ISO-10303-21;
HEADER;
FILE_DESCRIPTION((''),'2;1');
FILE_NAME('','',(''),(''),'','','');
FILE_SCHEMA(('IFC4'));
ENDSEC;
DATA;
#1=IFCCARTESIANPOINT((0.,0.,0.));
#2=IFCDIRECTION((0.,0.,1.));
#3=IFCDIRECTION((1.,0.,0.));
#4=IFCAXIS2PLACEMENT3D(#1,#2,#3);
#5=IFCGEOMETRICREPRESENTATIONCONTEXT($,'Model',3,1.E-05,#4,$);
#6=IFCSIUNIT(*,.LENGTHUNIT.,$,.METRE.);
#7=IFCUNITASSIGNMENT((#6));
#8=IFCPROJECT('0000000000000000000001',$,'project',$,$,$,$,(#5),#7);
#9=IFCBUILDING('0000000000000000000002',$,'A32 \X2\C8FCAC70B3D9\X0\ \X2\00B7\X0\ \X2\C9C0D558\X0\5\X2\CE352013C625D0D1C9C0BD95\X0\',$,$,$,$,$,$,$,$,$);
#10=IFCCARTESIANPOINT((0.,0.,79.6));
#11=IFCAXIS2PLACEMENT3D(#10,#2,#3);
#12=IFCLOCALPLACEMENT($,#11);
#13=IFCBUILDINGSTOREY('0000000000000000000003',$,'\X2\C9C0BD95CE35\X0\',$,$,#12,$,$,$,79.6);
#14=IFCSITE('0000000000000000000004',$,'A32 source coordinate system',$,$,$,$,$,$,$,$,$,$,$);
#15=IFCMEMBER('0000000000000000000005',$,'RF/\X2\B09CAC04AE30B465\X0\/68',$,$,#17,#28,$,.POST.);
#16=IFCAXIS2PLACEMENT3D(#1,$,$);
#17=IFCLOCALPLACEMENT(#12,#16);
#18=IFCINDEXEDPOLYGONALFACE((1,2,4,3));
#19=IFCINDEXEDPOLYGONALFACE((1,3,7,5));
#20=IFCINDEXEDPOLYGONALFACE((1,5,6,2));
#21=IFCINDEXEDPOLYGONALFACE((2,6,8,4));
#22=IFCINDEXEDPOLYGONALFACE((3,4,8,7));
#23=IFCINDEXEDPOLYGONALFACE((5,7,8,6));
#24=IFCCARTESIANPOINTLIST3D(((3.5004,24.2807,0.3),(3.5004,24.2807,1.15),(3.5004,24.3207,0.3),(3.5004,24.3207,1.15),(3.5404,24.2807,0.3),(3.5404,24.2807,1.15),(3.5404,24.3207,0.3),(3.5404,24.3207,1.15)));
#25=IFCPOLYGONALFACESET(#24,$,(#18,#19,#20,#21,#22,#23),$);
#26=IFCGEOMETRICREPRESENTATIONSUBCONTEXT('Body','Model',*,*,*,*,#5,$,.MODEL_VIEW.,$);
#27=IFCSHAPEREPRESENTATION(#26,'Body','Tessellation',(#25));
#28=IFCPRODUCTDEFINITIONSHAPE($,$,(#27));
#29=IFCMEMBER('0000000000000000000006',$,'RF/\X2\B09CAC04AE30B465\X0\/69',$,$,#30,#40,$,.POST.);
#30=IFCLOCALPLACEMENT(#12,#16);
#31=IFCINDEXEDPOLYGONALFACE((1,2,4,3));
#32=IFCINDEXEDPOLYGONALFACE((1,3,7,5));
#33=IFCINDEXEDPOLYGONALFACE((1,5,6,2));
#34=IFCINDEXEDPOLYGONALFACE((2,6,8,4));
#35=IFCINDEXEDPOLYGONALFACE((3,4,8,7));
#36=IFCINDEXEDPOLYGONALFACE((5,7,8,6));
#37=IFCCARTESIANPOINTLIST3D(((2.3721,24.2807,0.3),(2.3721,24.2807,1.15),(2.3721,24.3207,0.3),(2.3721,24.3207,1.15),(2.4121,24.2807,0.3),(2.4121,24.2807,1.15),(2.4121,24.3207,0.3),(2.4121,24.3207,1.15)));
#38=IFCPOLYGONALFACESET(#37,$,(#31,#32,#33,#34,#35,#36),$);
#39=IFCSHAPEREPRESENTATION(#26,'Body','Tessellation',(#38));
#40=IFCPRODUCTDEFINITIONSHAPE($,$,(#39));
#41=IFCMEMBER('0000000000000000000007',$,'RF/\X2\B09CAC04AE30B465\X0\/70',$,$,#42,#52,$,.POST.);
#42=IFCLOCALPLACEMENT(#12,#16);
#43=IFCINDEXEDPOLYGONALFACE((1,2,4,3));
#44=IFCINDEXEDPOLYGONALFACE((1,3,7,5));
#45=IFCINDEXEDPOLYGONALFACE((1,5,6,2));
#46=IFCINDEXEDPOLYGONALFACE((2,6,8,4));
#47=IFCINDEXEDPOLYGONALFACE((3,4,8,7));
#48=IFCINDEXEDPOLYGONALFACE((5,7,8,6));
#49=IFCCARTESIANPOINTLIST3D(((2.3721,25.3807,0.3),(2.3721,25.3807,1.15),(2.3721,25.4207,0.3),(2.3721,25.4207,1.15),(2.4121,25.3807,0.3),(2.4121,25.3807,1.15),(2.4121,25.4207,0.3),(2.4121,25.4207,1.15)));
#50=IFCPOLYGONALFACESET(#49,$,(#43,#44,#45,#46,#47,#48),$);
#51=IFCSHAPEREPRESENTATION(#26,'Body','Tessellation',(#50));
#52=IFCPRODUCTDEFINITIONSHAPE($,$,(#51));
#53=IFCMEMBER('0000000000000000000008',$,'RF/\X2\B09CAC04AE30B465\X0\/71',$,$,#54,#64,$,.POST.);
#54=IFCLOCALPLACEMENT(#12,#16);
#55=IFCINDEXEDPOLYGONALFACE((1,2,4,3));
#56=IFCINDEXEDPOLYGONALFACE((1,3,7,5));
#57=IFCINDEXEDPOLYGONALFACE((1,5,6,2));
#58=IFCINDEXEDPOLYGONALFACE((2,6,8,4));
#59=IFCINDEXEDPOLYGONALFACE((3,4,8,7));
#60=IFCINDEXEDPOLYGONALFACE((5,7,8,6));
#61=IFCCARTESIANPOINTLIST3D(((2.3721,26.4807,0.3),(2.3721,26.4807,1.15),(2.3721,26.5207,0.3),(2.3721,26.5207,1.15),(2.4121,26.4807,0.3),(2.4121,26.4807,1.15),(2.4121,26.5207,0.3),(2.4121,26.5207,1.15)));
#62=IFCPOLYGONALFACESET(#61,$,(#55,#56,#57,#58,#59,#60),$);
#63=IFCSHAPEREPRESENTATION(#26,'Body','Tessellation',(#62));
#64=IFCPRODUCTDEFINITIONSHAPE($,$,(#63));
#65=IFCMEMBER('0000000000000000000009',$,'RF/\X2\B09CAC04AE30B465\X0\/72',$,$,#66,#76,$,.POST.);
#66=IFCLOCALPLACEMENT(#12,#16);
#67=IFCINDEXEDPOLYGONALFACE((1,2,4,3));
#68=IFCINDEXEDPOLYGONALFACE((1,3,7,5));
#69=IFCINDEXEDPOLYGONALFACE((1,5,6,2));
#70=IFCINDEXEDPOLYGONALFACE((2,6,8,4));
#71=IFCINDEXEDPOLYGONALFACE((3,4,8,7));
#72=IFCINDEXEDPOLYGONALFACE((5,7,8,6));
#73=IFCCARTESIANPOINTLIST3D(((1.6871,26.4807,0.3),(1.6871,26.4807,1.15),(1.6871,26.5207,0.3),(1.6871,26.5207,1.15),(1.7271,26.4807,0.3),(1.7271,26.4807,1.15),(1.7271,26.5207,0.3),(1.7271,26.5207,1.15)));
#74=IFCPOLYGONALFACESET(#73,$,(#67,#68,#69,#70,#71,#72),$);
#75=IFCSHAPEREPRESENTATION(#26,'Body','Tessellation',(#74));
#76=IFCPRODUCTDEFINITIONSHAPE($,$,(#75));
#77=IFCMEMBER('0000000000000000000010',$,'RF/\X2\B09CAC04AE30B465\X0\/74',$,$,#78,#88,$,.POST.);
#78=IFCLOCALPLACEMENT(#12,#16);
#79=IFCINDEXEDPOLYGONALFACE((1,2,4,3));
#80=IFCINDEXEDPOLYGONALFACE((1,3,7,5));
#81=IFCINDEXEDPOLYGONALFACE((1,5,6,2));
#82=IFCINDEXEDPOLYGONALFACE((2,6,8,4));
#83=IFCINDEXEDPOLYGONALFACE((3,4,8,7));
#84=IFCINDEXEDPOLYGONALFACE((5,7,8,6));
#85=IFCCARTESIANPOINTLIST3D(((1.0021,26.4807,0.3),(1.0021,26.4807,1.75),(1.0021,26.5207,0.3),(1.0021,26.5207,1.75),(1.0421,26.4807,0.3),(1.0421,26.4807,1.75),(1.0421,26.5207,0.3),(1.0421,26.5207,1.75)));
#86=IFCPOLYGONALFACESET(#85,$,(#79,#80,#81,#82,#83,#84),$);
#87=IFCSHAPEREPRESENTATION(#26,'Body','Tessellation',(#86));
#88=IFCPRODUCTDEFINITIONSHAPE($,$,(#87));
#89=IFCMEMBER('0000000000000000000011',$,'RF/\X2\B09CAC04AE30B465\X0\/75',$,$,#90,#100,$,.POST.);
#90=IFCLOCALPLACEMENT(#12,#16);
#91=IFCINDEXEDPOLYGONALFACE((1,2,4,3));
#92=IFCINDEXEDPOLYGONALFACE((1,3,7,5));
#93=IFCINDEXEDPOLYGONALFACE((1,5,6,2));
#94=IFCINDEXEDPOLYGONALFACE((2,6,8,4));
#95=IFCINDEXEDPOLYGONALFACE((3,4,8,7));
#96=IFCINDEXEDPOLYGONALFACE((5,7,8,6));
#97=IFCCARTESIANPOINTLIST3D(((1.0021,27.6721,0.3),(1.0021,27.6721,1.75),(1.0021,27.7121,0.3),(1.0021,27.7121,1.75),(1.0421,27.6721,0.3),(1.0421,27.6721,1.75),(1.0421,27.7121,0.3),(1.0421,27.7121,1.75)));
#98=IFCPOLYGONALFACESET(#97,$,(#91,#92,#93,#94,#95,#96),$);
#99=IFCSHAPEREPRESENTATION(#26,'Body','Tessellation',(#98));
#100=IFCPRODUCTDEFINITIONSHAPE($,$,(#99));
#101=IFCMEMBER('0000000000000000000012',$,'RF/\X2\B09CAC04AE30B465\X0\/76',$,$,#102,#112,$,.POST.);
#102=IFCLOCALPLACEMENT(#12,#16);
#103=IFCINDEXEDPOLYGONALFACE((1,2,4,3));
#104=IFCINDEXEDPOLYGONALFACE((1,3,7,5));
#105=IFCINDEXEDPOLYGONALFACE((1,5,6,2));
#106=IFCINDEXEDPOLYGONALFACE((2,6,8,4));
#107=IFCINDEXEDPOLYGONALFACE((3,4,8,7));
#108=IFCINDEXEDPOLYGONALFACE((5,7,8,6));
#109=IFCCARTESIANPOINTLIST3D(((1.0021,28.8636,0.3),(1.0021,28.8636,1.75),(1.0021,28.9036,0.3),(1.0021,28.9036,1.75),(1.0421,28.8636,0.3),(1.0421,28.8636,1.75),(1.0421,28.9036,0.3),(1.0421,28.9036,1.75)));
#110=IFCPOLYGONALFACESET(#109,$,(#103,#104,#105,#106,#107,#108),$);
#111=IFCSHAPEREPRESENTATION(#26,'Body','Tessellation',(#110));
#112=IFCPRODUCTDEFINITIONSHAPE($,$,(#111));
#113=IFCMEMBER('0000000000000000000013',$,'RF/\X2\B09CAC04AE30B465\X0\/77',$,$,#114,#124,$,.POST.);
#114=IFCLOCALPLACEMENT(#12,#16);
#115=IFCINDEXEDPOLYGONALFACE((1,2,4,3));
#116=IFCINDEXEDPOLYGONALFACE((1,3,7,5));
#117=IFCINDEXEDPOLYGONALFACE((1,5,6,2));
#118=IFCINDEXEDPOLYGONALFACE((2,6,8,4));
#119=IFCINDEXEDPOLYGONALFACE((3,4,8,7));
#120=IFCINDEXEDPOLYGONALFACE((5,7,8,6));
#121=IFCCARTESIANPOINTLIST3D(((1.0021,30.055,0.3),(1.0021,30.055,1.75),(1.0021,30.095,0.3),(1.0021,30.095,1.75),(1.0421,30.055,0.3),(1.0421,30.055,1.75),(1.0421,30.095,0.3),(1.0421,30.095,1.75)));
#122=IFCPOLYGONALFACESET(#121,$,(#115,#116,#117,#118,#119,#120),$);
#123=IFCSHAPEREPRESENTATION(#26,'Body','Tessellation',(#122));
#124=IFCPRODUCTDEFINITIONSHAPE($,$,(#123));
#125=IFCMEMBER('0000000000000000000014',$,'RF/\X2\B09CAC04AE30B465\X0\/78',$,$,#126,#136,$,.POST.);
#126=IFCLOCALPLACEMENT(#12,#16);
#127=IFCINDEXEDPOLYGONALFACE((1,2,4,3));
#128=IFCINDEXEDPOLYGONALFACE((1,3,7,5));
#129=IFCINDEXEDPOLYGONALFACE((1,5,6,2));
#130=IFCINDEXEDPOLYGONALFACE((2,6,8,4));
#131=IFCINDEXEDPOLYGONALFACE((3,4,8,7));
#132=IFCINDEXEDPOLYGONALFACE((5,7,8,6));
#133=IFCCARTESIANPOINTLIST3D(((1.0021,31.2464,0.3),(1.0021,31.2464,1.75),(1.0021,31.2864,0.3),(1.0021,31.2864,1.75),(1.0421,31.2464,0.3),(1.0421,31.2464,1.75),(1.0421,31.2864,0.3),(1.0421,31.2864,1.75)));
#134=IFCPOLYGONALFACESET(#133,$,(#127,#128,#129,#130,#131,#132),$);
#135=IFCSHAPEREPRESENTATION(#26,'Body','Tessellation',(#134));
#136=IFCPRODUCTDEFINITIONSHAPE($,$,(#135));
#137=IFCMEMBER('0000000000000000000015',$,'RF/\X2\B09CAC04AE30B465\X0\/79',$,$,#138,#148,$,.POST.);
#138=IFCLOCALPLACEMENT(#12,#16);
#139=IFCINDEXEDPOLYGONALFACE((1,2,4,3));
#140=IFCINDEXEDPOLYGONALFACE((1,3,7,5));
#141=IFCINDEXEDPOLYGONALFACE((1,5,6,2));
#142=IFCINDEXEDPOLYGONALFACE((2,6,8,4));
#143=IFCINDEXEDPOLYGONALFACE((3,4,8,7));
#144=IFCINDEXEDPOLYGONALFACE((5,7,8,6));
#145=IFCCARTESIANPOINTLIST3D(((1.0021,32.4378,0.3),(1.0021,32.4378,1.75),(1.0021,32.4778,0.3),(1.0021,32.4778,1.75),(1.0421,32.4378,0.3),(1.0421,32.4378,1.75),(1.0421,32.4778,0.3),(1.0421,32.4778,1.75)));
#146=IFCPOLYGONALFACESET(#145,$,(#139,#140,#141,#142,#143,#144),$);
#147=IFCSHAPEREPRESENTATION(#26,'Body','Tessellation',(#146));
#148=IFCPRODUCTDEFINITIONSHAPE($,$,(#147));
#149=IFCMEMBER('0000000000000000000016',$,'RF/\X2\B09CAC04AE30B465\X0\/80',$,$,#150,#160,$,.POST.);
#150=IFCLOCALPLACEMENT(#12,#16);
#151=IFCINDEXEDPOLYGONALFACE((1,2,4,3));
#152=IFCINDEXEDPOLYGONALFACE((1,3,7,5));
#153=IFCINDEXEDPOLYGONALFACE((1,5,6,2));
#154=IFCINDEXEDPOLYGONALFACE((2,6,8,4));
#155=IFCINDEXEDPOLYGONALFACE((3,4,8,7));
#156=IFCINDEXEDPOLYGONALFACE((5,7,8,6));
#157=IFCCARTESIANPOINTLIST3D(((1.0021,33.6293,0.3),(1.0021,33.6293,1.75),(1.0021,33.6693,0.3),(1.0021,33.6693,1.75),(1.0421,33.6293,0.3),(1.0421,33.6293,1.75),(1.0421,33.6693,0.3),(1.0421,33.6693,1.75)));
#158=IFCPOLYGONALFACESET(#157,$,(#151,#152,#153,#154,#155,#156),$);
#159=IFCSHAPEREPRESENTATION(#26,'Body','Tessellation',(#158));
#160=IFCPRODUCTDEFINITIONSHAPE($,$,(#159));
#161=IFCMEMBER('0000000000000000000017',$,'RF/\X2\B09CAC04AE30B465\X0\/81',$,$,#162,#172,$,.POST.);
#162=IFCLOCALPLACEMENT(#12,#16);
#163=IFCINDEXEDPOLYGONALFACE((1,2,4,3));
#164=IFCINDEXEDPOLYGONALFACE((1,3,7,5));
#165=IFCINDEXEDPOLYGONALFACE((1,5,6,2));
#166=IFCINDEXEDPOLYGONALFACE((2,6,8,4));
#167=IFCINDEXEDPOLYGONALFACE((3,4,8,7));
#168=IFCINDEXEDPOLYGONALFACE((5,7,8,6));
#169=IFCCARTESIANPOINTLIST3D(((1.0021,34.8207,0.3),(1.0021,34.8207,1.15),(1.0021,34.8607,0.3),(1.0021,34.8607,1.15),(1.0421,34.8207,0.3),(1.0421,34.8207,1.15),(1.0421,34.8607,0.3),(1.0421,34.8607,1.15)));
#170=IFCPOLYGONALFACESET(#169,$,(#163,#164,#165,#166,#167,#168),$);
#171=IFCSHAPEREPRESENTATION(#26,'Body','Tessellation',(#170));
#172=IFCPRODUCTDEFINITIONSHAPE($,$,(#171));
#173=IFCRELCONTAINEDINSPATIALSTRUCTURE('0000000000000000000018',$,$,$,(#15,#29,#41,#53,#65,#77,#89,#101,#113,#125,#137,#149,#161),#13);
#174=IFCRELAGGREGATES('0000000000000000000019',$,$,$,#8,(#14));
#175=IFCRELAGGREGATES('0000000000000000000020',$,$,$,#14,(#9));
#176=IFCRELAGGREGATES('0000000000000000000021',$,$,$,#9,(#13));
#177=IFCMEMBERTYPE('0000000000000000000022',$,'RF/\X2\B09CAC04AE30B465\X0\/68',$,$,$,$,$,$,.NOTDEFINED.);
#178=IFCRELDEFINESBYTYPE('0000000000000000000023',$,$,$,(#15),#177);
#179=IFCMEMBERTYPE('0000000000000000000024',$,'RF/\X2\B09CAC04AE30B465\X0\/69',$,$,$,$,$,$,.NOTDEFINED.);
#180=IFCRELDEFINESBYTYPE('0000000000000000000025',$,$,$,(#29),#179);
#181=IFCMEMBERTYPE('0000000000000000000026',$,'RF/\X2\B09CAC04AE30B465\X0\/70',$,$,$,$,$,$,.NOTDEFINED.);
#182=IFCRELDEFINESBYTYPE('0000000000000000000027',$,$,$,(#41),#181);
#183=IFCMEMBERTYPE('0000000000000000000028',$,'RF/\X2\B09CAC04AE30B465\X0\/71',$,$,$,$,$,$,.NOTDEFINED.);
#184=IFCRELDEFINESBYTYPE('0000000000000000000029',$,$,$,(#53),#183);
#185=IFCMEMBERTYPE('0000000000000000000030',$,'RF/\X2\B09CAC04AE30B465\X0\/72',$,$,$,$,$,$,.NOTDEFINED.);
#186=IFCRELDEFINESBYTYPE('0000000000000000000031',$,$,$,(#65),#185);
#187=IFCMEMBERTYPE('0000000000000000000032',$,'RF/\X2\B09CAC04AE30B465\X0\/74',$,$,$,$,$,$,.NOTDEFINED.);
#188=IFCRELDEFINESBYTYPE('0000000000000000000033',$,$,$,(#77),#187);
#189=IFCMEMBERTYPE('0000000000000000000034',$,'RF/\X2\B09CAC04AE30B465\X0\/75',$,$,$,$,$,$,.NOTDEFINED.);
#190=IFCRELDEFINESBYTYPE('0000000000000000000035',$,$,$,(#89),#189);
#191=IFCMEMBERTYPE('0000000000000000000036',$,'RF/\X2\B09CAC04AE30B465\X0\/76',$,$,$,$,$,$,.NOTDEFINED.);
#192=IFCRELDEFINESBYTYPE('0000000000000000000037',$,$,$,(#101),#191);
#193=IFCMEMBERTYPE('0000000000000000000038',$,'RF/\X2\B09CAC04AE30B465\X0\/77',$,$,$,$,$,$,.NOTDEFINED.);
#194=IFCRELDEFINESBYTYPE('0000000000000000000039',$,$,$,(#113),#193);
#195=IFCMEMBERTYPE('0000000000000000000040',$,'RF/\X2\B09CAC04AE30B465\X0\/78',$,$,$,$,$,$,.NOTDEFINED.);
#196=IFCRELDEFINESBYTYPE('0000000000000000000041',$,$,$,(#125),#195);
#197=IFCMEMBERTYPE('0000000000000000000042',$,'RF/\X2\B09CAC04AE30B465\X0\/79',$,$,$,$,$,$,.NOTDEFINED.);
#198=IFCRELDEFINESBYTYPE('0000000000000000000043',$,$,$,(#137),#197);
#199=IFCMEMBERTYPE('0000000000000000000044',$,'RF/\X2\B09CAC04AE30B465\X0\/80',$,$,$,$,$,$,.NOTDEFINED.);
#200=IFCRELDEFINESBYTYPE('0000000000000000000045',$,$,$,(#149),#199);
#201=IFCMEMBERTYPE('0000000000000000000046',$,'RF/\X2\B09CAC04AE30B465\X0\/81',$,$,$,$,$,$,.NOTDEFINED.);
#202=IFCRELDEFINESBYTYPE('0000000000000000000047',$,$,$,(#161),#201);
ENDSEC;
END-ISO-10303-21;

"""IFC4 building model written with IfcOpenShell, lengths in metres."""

from ifc_helpers import new_model, si_unit, frame, origin, origin_with_axes, place, context, subcontext, project, spatial, polyline, outline, extrude, source, transform, mapped, type_object, type_shapes, element, save


model = new_model("IFC4")

# Units and contexts
model_context = context("Model", 3, precision=1e-05, world=origin_with_axes())
body_context = subcontext(model_context, "Body", "Model", "MODEL_VIEW")
ifc_project = project(units=[si_unit("LENGTHUNIT", "METRE")], contexts=[model_context])

# Site, building, storey
site = spatial("IfcSite", under=ifc_project, Name="A32 source coordinate system")
building = spatial("IfcBuilding", under=site, Name="A32 주거동 · 지하5층–옥탑지붕")
storey_placement = place(None, frame((0.0, 0.0, 79.6), z_axis=(0.0, 0.0, 1.0), x_axis=(1.0, 0.0, 0.0)))
storey = spatial("IfcBuildingStorey", under=building, at=storey_placement, Name="지붕층", Elevation=79.6)

# Members
member_type_1 = type_object("IfcMemberType", Name="RF/난간기둥/68", PredefinedType="NOTDEFINED")
shared_shape_1 = source(origin(), body_context, "Body", "SweptSolid", [
    extrude(outline(polyline([(3.5404, 24.2807), (3.5004, 24.2807), (3.5004, 24.3207), (3.5404, 24.3207), (3.5404, 24.2807)])), frame((0.0, 0.0, 0.3)), (0.0, 0.0, 1.0), 0.85),
])
type_shapes(member_type_1, [shared_shape_1])
member_1_placement = place(storey_placement, origin_with_axes())
element("IfcMember", 1, at=member_1_placement, inside=storey, type_object=member_type_1, Name="RF/난간기둥/68", PredefinedType="POST", context=body_context, shape_type="MappedRepresentation", body=[
    mapped(shared_shape_1, transform((0.0, 0.0, 0.0), scale=1.0)),
])
member_type_2 = type_object("IfcMemberType", Name="RF/난간기둥/69", PredefinedType="NOTDEFINED")
shared_shape_2 = source(origin(), body_context, "Body", "SweptSolid", [
    extrude(outline(polyline([(2.4121, 24.2807), (2.3721, 24.2807), (2.3721, 24.3207), (2.4121, 24.3207), (2.4121, 24.2807)])), frame((0.0, 0.0, 0.3)), (0.0, 0.0, 1.0), 0.85),
])
type_shapes(member_type_2, [shared_shape_2])
member_2_placement = place(storey_placement, origin_with_axes())
element("IfcMember", 2, at=member_2_placement, inside=storey, type_object=member_type_2, Name="RF/난간기둥/69", PredefinedType="POST", context=body_context, shape_type="MappedRepresentation", body=[
    mapped(shared_shape_2, transform((0.0, 0.0, 0.0), scale=1.0)),
])
member_type_3 = type_object("IfcMemberType", Name="RF/난간기둥/70", PredefinedType="NOTDEFINED")
shared_shape_3 = source(origin(), body_context, "Body", "SweptSolid", [
    extrude(outline(polyline([(2.4121, 25.3807), (2.3721, 25.3807), (2.3721, 25.4207), (2.4121, 25.4207), (2.4121, 25.3807)])), frame((0.0, 0.0, 0.3)), (0.0, 0.0, 1.0), 0.85),
])
type_shapes(member_type_3, [shared_shape_3])
member_3_placement = place(storey_placement, origin_with_axes())
element("IfcMember", 3, at=member_3_placement, inside=storey, type_object=member_type_3, Name="RF/난간기둥/70", PredefinedType="POST", context=body_context, shape_type="MappedRepresentation", body=[
    mapped(shared_shape_3, transform((0.0, 0.0, 0.0), scale=1.0)),
])
member_type_4 = type_object("IfcMemberType", Name="RF/난간기둥/71", PredefinedType="NOTDEFINED")
shared_shape_4 = source(origin(), body_context, "Body", "SweptSolid", [
    extrude(outline(polyline([(2.4121, 26.4807), (2.3721, 26.4807), (2.3721, 26.5207), (2.4121, 26.5207), (2.4121, 26.4807)])), frame((0.0, 0.0, 0.3)), (0.0, 0.0, 1.0), 0.85),
])
type_shapes(member_type_4, [shared_shape_4])
member_4_placement = place(storey_placement, origin_with_axes())
element("IfcMember", 4, at=member_4_placement, inside=storey, type_object=member_type_4, Name="RF/난간기둥/71", PredefinedType="POST", context=body_context, shape_type="MappedRepresentation", body=[
    mapped(shared_shape_4, transform((0.0, 0.0, 0.0), scale=1.0)),
])
member_type_5 = type_object("IfcMemberType", Name="RF/난간기둥/72", PredefinedType="NOTDEFINED")
shared_shape_5 = source(origin(), body_context, "Body", "SweptSolid", [
    extrude(outline(polyline([(1.7271, 26.4807), (1.6871, 26.4807), (1.6871, 26.5207), (1.7271, 26.5207), (1.7271, 26.4807)])), frame((0.0, 0.0, 0.3)), (0.0, 0.0, 1.0), 0.85),
])
type_shapes(member_type_5, [shared_shape_5])
member_5_placement = place(storey_placement, origin_with_axes())
element("IfcMember", 5, at=member_5_placement, inside=storey, type_object=member_type_5, Name="RF/난간기둥/72", PredefinedType="POST", context=body_context, shape_type="MappedRepresentation", body=[
    mapped(shared_shape_5, transform((0.0, 0.0, 0.0), scale=1.0)),
])
member_type_6 = type_object("IfcMemberType", Name="RF/난간기둥/74", PredefinedType="NOTDEFINED")
shared_shape_6 = source(origin(), body_context, "Body", "SweptSolid", [
    extrude(outline(polyline([(1.0421, 26.4807), (1.0021, 26.4807), (1.0021, 26.5207), (1.0421, 26.5207), (1.0421, 26.4807)])), frame((0.0, 0.0, 0.3)), (0.0, 0.0, 1.0), 1.45),
])
type_shapes(member_type_6, [shared_shape_6])
member_6_placement = place(storey_placement, origin_with_axes())
element("IfcMember", 6, at=member_6_placement, inside=storey, type_object=member_type_6, Name="RF/난간기둥/74", PredefinedType="POST", context=body_context, shape_type="MappedRepresentation", body=[
    mapped(shared_shape_6, transform((0.0, 0.0, 0.0), scale=1.0)),
])
member_type_7 = type_object("IfcMemberType", Name="RF/난간기둥/75", PredefinedType="NOTDEFINED")
shared_shape_7 = source(origin(), body_context, "Body", "SweptSolid", [
    extrude(outline(polyline([(1.0421, 27.6721), (1.0021, 27.6721), (1.0021, 27.7121), (1.0421, 27.7121), (1.0421, 27.6721)])), frame((0.0, 0.0, 0.3)), (0.0, 0.0, 1.0), 1.45),
])
type_shapes(member_type_7, [shared_shape_7])
member_7_placement = place(storey_placement, origin_with_axes())
element("IfcMember", 7, at=member_7_placement, inside=storey, type_object=member_type_7, Name="RF/난간기둥/75", PredefinedType="POST", context=body_context, shape_type="MappedRepresentation", body=[
    mapped(shared_shape_7, transform((0.0, 0.0, 0.0), scale=1.0)),
])
member_type_8 = type_object("IfcMemberType", Name="RF/난간기둥/76", PredefinedType="NOTDEFINED")
shared_shape_8 = source(origin(), body_context, "Body", "SweptSolid", [
    extrude(outline(polyline([(1.0421, 28.8636), (1.0021, 28.8636), (1.0021, 28.9036), (1.0421, 28.9036), (1.0421, 28.8636)])), frame((0.0, 0.0, 0.3)), (0.0, 0.0, 1.0), 1.45),
])
type_shapes(member_type_8, [shared_shape_8])
member_8_placement = place(storey_placement, origin_with_axes())
element("IfcMember", 8, at=member_8_placement, inside=storey, type_object=member_type_8, Name="RF/난간기둥/76", PredefinedType="POST", context=body_context, shape_type="MappedRepresentation", body=[
    mapped(shared_shape_8, transform((0.0, 0.0, 0.0), scale=1.0)),
])
member_type_9 = type_object("IfcMemberType", Name="RF/난간기둥/77", PredefinedType="NOTDEFINED")
shared_shape_9 = source(origin(), body_context, "Body", "SweptSolid", [
    extrude(outline(polyline([(1.0421, 30.055), (1.0021, 30.055), (1.0021, 30.095), (1.0421, 30.095), (1.0421, 30.055)])), frame((0.0, 0.0, 0.3)), (0.0, 0.0, 1.0), 1.45),
])
type_shapes(member_type_9, [shared_shape_9])
member_9_placement = place(storey_placement, origin_with_axes())
element("IfcMember", 9, at=member_9_placement, inside=storey, type_object=member_type_9, Name="RF/난간기둥/77", PredefinedType="POST", context=body_context, shape_type="MappedRepresentation", body=[
    mapped(shared_shape_9, transform((0.0, 0.0, 0.0), scale=1.0)),
])
member_type_10 = type_object("IfcMemberType", Name="RF/난간기둥/78", PredefinedType="NOTDEFINED")
shared_shape_10 = source(origin(), body_context, "Body", "SweptSolid", [
    extrude(outline(polyline([(1.0421, 31.2464), (1.0021, 31.2464), (1.0021, 31.2864), (1.0421, 31.2864), (1.0421, 31.2464)])), frame((0.0, 0.0, 0.3)), (0.0, 0.0, 1.0), 1.45),
])
type_shapes(member_type_10, [shared_shape_10])
member_10_placement = place(storey_placement, origin_with_axes())
element("IfcMember", 10, at=member_10_placement, inside=storey, type_object=member_type_10, Name="RF/난간기둥/78", PredefinedType="POST", context=body_context, shape_type="MappedRepresentation", body=[
    mapped(shared_shape_10, transform((0.0, 0.0, 0.0), scale=1.0)),
])
member_type_11 = type_object("IfcMemberType", Name="RF/난간기둥/79", PredefinedType="NOTDEFINED")
shared_shape_11 = source(origin(), body_context, "Body", "SweptSolid", [
    extrude(outline(polyline([(1.0421, 32.4378), (1.0021, 32.4378), (1.0021, 32.4778), (1.0421, 32.4778), (1.0421, 32.4378)])), frame((0.0, 0.0, 0.3)), (0.0, 0.0, 1.0), 1.45),
])
type_shapes(member_type_11, [shared_shape_11])
member_11_placement = place(storey_placement, origin_with_axes())
element("IfcMember", 11, at=member_11_placement, inside=storey, type_object=member_type_11, Name="RF/난간기둥/79", PredefinedType="POST", context=body_context, shape_type="MappedRepresentation", body=[
    mapped(shared_shape_11, transform((0.0, 0.0, 0.0), scale=1.0)),
])
member_type_12 = type_object("IfcMemberType", Name="RF/난간기둥/80", PredefinedType="NOTDEFINED")
shared_shape_12 = source(origin(), body_context, "Body", "SweptSolid", [
    extrude(outline(polyline([(1.0421, 33.6293), (1.0021, 33.6293), (1.0021, 33.6693), (1.0421, 33.6693), (1.0421, 33.6293)])), frame((0.0, 0.0, 0.3)), (0.0, 0.0, 1.0), 1.45),
])
type_shapes(member_type_12, [shared_shape_12])
member_12_placement = place(storey_placement, origin_with_axes())
element("IfcMember", 12, at=member_12_placement, inside=storey, type_object=member_type_12, Name="RF/난간기둥/80", PredefinedType="POST", context=body_context, shape_type="MappedRepresentation", body=[
    mapped(shared_shape_12, transform((0.0, 0.0, 0.0), scale=1.0)),
])
member_type_13 = type_object("IfcMemberType", Name="RF/난간기둥/81", PredefinedType="NOTDEFINED")
shared_shape_13 = source(origin(), body_context, "Body", "SweptSolid", [
    extrude(outline(polyline([(1.0421, 34.8207), (1.0021, 34.8207), (1.0021, 34.8607), (1.0421, 34.8607), (1.0421, 34.8207)])), frame((0.0, 0.0, 0.3)), (0.0, 0.0, 1.0), 0.85),
])
type_shapes(member_type_13, [shared_shape_13])
member_13_placement = place(storey_placement, origin_with_axes())
element("IfcMember", 13, at=member_13_placement, inside=storey, type_object=member_type_13, Name="RF/난간기둥/81", PredefinedType="POST", context=body_context, shape_type="MappedRepresentation", body=[
    mapped(shared_shape_13, transform((0.0, 0.0, 0.0), scale=1.0)),
])

save(model, "model.ifc")
